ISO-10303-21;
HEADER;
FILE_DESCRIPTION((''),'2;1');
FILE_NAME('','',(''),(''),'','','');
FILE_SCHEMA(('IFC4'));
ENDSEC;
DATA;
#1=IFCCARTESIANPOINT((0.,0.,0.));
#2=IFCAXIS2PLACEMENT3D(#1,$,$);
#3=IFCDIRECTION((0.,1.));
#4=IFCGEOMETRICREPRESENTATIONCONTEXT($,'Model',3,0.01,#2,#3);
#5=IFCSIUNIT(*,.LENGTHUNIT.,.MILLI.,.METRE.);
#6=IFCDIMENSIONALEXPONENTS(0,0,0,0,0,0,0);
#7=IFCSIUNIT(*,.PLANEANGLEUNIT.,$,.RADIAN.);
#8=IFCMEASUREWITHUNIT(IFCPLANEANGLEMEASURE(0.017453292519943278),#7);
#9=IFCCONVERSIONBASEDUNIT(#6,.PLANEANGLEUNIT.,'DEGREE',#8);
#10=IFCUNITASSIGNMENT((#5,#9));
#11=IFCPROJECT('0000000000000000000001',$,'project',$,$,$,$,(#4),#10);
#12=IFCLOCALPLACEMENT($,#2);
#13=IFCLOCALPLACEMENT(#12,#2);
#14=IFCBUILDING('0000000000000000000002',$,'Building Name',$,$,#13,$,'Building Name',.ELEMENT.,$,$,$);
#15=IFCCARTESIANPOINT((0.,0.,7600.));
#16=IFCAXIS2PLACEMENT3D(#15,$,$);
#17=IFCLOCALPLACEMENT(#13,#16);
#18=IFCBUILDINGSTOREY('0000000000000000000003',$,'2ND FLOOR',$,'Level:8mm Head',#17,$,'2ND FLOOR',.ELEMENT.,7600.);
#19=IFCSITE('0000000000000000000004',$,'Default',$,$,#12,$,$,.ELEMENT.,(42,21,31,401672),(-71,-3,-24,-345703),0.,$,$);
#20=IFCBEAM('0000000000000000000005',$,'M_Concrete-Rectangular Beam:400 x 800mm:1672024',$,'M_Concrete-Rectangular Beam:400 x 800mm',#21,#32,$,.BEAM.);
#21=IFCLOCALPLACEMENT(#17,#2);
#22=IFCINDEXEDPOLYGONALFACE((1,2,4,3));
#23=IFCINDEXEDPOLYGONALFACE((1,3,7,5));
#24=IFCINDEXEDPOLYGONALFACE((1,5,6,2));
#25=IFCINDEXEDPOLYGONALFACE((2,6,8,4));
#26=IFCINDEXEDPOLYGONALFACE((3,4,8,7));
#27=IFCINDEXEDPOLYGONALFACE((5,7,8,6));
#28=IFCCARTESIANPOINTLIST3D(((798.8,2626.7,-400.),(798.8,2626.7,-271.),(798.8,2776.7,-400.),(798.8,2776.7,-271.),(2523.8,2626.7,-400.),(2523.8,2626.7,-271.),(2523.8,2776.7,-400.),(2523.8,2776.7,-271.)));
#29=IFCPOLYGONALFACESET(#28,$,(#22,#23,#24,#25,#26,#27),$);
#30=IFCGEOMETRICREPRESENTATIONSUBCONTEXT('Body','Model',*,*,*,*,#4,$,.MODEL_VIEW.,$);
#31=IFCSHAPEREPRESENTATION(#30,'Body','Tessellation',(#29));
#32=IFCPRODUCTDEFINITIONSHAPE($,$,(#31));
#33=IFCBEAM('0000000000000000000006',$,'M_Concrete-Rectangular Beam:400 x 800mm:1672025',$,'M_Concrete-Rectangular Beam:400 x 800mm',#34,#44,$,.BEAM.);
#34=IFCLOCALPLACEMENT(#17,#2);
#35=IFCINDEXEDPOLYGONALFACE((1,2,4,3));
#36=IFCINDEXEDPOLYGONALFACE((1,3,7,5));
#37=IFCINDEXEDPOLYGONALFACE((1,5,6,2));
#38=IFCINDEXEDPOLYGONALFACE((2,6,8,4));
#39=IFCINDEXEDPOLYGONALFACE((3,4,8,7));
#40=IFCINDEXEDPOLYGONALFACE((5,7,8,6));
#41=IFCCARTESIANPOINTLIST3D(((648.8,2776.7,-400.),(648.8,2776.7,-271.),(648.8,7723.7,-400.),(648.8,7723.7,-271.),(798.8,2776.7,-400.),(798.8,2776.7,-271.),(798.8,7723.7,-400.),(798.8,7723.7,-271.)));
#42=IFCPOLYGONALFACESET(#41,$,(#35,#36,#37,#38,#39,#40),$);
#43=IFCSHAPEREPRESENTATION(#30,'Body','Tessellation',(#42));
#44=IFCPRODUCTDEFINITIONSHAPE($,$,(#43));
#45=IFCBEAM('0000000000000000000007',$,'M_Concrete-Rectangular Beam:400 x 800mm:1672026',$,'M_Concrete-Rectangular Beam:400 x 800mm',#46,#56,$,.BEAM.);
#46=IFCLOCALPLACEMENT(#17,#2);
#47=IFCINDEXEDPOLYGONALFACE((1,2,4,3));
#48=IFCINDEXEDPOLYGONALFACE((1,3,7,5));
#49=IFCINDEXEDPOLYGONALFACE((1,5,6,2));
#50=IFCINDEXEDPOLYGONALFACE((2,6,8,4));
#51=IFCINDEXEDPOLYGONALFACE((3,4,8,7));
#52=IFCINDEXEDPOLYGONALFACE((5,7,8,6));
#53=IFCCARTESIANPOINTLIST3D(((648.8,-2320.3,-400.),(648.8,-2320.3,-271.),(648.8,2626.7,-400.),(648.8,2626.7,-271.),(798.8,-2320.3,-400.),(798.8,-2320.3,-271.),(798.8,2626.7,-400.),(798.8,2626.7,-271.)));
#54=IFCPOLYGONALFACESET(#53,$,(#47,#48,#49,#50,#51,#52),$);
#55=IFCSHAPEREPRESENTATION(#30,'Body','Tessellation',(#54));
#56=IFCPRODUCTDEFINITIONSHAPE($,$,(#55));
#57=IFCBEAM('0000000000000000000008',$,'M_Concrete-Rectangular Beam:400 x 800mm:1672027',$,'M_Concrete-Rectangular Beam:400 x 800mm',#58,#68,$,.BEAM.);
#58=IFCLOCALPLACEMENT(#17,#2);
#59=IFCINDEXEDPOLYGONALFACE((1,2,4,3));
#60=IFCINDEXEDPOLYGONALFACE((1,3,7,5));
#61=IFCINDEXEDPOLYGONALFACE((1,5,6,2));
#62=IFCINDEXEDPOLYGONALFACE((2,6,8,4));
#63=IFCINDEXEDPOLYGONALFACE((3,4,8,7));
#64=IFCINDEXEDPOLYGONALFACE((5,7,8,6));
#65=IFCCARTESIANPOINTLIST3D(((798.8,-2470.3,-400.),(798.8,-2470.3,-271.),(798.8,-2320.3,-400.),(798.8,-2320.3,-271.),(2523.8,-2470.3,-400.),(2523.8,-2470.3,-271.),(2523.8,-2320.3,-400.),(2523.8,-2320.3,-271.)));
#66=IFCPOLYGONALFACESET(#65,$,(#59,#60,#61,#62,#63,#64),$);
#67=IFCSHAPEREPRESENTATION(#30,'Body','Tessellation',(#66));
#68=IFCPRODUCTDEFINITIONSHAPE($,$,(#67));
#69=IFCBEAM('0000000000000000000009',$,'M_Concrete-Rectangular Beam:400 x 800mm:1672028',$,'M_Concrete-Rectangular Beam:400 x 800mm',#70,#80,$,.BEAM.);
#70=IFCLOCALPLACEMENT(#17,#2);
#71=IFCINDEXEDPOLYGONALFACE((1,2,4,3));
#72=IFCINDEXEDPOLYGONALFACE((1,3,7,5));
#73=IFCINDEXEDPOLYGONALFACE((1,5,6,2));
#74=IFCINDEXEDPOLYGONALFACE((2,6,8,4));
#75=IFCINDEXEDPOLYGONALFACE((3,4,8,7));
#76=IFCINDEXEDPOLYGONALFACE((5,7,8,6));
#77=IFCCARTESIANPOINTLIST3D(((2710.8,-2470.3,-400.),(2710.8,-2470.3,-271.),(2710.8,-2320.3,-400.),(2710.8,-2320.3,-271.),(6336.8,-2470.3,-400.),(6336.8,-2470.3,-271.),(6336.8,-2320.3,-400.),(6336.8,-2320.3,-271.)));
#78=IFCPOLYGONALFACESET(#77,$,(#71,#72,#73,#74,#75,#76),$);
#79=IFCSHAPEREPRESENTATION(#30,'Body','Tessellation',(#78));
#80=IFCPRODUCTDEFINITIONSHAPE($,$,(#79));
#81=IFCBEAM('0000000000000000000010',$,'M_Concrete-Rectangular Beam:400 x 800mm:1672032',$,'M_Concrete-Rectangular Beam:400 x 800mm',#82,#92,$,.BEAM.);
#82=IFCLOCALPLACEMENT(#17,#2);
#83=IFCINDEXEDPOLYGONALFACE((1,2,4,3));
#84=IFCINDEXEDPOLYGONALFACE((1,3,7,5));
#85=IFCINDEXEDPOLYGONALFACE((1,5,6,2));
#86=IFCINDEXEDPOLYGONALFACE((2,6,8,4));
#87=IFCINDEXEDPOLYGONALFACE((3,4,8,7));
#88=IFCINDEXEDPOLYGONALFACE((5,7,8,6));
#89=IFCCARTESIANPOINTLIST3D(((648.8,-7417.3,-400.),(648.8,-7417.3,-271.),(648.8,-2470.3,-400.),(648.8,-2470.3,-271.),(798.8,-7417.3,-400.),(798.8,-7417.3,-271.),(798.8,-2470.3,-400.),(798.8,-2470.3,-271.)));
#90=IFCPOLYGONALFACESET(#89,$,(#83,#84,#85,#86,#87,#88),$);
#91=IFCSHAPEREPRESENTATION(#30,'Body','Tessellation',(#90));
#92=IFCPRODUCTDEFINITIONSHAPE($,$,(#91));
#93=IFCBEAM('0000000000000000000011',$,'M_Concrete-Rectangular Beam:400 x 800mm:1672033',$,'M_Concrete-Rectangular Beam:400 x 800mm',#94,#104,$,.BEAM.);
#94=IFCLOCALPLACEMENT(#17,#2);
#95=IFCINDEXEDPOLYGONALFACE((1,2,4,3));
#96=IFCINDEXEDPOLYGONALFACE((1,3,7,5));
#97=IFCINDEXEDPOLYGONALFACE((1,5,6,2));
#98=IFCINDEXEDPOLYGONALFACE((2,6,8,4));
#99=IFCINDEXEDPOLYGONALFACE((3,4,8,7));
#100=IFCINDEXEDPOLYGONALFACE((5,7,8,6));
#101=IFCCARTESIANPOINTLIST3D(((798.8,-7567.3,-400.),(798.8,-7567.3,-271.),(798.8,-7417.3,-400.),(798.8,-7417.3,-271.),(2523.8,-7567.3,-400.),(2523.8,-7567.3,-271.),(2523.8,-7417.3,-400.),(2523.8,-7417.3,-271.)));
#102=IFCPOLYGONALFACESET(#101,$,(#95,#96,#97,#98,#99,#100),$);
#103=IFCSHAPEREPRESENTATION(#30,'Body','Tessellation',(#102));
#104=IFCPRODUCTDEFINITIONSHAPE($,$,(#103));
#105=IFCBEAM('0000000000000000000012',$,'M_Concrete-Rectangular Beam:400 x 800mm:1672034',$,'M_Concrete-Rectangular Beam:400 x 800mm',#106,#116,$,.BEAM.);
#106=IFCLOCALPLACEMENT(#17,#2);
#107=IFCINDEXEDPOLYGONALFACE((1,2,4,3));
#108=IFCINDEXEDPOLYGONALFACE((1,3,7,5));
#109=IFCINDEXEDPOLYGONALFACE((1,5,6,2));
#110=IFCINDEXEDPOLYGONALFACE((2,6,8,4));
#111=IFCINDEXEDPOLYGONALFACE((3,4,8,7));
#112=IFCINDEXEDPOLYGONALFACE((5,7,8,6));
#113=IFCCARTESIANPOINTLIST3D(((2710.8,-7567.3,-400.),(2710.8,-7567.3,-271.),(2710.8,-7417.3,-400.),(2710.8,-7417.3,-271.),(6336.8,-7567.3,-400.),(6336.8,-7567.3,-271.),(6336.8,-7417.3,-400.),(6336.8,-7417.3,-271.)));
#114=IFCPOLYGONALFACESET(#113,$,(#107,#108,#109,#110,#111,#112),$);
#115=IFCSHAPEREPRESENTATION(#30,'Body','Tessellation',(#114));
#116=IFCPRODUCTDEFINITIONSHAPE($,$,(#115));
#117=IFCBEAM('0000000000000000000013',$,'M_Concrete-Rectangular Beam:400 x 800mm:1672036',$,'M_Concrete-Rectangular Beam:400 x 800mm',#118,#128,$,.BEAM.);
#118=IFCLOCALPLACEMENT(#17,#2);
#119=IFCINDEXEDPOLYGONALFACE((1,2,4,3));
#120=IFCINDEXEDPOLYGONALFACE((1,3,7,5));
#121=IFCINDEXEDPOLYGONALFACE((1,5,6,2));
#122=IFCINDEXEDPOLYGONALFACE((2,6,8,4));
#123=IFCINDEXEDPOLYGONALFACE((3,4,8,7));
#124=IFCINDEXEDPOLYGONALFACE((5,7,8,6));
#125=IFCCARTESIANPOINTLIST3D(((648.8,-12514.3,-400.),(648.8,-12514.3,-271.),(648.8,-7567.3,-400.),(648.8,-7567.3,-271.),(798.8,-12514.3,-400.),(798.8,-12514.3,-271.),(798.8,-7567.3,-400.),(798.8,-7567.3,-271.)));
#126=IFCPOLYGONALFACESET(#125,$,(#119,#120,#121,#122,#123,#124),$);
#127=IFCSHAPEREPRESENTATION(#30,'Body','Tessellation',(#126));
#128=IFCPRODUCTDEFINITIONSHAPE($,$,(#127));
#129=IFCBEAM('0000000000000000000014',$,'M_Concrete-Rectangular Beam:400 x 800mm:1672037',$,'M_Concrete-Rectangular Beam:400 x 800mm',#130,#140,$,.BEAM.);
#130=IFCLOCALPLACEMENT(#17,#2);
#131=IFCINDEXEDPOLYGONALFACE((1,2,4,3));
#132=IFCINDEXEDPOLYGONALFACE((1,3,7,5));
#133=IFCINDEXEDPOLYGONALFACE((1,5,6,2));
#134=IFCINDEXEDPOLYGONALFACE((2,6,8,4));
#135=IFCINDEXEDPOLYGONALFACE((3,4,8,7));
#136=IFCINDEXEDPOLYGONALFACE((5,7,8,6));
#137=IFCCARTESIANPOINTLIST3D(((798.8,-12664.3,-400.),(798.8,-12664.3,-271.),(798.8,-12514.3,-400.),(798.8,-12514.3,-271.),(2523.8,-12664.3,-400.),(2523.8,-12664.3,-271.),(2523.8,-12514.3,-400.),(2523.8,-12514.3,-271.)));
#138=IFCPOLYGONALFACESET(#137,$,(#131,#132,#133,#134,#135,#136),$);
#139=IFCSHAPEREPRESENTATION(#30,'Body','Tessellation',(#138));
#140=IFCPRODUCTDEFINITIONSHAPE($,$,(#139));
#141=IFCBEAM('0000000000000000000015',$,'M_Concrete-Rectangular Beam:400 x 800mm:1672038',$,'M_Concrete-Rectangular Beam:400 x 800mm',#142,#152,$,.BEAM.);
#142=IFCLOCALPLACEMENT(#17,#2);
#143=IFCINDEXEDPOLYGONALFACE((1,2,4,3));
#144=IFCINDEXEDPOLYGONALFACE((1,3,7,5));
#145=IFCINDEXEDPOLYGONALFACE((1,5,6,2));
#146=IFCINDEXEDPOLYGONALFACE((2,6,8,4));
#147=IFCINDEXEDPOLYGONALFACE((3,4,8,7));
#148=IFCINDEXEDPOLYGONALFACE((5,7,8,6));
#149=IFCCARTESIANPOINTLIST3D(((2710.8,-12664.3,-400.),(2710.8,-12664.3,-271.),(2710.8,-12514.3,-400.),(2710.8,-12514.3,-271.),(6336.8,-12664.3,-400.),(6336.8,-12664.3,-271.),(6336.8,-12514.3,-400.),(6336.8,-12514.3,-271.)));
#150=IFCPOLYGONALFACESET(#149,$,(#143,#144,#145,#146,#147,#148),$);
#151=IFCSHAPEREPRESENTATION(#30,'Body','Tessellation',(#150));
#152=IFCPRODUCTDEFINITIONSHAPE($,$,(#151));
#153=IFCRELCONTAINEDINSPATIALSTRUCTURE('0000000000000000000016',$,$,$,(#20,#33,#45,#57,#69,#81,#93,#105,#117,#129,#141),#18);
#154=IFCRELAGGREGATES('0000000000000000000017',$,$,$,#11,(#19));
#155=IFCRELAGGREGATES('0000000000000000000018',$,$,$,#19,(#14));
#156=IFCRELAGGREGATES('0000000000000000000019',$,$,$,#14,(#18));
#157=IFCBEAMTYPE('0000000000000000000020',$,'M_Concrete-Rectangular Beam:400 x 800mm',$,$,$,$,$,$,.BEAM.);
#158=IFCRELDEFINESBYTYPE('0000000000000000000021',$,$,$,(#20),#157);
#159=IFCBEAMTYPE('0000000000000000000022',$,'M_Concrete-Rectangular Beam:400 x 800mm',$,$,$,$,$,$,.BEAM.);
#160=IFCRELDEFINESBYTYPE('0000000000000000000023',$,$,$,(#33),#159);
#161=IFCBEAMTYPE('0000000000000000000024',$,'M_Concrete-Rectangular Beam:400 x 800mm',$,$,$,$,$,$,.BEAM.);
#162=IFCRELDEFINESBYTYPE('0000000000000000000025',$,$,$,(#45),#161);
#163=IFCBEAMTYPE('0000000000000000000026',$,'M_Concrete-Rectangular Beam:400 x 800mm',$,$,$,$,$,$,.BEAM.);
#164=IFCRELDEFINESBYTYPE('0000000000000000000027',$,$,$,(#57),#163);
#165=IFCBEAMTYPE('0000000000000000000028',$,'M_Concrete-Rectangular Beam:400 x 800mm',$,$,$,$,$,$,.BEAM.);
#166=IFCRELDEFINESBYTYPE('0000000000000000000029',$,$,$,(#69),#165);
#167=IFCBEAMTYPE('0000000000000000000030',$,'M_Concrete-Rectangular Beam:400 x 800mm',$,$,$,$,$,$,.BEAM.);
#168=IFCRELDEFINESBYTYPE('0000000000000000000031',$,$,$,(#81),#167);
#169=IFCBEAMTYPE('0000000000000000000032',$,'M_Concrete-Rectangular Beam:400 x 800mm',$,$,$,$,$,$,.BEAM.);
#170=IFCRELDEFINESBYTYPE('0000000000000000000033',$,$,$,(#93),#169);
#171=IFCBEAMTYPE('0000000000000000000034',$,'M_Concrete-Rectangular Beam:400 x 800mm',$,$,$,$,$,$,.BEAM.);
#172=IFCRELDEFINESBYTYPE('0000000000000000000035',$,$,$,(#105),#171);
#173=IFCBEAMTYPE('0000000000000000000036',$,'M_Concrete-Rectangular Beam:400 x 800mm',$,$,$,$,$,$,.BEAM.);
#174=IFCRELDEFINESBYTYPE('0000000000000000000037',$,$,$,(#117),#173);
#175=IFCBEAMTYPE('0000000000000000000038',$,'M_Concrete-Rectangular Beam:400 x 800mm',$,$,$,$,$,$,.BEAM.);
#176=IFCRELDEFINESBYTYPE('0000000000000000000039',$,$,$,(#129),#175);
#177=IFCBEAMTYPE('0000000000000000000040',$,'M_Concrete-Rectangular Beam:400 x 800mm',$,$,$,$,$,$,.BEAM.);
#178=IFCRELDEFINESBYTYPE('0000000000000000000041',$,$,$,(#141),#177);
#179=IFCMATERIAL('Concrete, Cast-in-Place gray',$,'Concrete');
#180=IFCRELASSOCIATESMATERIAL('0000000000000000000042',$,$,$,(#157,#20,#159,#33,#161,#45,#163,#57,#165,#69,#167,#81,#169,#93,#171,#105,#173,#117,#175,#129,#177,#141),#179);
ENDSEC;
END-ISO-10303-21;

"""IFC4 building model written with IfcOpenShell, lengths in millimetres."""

from ifc_helpers import new_model, entity, si_unit, converted_unit, direction, frame, origin, place, context, subcontext, project, spatial, indexed_curve, outline, extrude, source, transform, mapped, material, type_object, type_shapes, element, save


model = new_model("IFC4")

# Units and contexts
model_context = context("Model", 3, precision=0.01, world=origin(), true_north=direction((0.0, 1.0)))
body_context = subcontext(model_context, "Body", "Model", "MODEL_VIEW")
ifc_project = project(units=[si_unit("LENGTHUNIT", "METRE", prefix="MILLI"), converted_unit("PLANEANGLEUNIT", "DEGREE", entity("IfcPlaneAngleMeasure", 0.017453292519943278), si_unit("PLANEANGLEUNIT", "RADIAN"), dimensions=[0, 0, 0, 0, 0, 0, 0])], contexts=[model_context])

# Site, building, storey
site_placement = place(None, origin())
site = spatial("IfcSite", under=ifc_project, at=site_placement, Name="Default", CompositionType="ELEMENT", RefLatitude=(42, 21, 31, 401672), RefLongitude=(-71, -3, -24, -345703), RefElevation=0.0)
building_placement = place(site_placement, origin())
building = spatial("IfcBuilding", under=site, at=building_placement, Name="Building Name", LongName="Building Name", CompositionType="ELEMENT")
storey_placement = place(building_placement, frame((0.0, 0.0, 7600.0)))
storey = spatial("IfcBuildingStorey", under=building, at=storey_placement, Name="2ND FLOOR", ObjectType="Level:8mm Head", LongName="2ND FLOOR", CompositionType="ELEMENT", Elevation=7600.0)

# Shared definitions
ifc_material_1 = material(Name="Concrete, Cast-in-Place gray", Category="Concrete")

# Beams
beam_type_1 = type_object("IfcBeamType", Name="M_Concrete-Rectangular Beam:400 x 800mm", PredefinedType="BEAM", material=ifc_material_1)
shared_shape_1 = source(origin(), body_context, "Body", "SweptSolid", [
    extrude(outline(indexed_curve([(-64.5, -75.0), (64.5, -75.0), (64.5, 75.0), (-64.5, 75.0), (-64.5, -75.0)], self_intersect=False)), frame((2523.8, 2701.7, 7264.5), z_axis=(-1.0, 0.0, 0.0), x_axis=(0.0, 0.0, -1.0)), (0.0, 0.0, 1.0), 1725.0),
])
type_shapes(beam_type_1, [shared_shape_1])
beam_1_placement = place(storey_placement, frame((0.0, 0.0, -7600.0)))
element("IfcBeam", 1, at=beam_1_placement, inside=storey, type_object=beam_type_1, material=ifc_material_1, Name="M_Concrete-Rectangular Beam:400 x 800mm:1672024", ObjectType="M_Concrete-Rectangular Beam:400 x 800mm", PredefinedType="BEAM", context=body_context, shape_type="MappedRepresentation", body=[
    mapped(shared_shape_1, transform((0.0, 0.0, 0.0), scale=1.0)),
])
beam_type_2 = type_object("IfcBeamType", Name="M_Concrete-Rectangular Beam:400 x 800mm", PredefinedType="BEAM", material=ifc_material_1)
shared_shape_2 = source(origin(), body_context, "Body", "SweptSolid", [
    extrude(outline(indexed_curve([(-75.0, -64.5), (75.0, -64.5), (75.0, 64.5), (-75.0, 64.5), (-75.0, -64.5)], self_intersect=False)), frame((723.8, 2776.7, 7264.5), z_axis=(0.0, 1.0, 0.0), x_axis=(-1.0, 0.0, 0.0)), (0.0, 0.0, 1.0), 4947.0),
])
type_shapes(beam_type_2, [shared_shape_2])
beam_2_placement = place(storey_placement, frame((0.0, 0.0, -7600.0)))
element("IfcBeam", 2, at=beam_2_placement, inside=storey, type_object=beam_type_2, material=ifc_material_1, Name="M_Concrete-Rectangular Beam:400 x 800mm:1672025", ObjectType="M_Concrete-Rectangular Beam:400 x 800mm", PredefinedType="BEAM", context=body_context, shape_type="MappedRepresentation", body=[
    mapped(shared_shape_2, transform((0.0, 0.0, 0.0), scale=1.0)),
])
beam_type_3 = type_object("IfcBeamType", Name="M_Concrete-Rectangular Beam:400 x 800mm", PredefinedType="BEAM", material=ifc_material_1)
shared_shape_3 = source(origin(), body_context, "Body", "SweptSolid", [
    extrude(outline(indexed_curve([(-75.0, -64.5), (75.0, -64.5), (75.0, 64.5), (-75.0, 64.5), (-75.0, -64.5)], self_intersect=False)), frame((723.8, 2626.7, 7264.5), z_axis=(0.0, -1.0, 0.0), x_axis=(-1.0, 0.0, 0.0)), (0.0, 0.0, 1.0), 4947.0),
])
type_shapes(beam_type_3, [shared_shape_3])
beam_3_placement = place(storey_placement, frame((0.0, 0.0, -7600.0)))
element("IfcBeam", 3, at=beam_3_placement, inside=storey, type_object=beam_type_3, material=ifc_material_1, Name="M_Concrete-Rectangular Beam:400 x 800mm:1672026", ObjectType="M_Concrete-Rectangular Beam:400 x 800mm", PredefinedType="BEAM", context=body_context, shape_type="MappedRepresentation", body=[
    mapped(shared_shape_3, transform((0.0, 0.0, 0.0), scale=1.0)),
])
beam_type_4 = type_object("IfcBeamType", Name="M_Concrete-Rectangular Beam:400 x 800mm", PredefinedType="BEAM", material=ifc_material_1)
shared_shape_4 = source(origin(), body_context, "Body", "SweptSolid", [
    extrude(outline(indexed_curve([(-64.5, -75.0), (64.5, -75.0), (64.5, 75.0), (-64.5, 75.0), (-64.5, -75.0)], self_intersect=False)), frame((798.8, -2395.3, 7264.5), z_axis=(1.0, 0.0, 0.0), x_axis=(0.0, 0.0, -1.0)), (0.0, 0.0, 1.0), 1725.0),
])
type_shapes(beam_type_4, [shared_shape_4])
beam_4_placement = place(storey_placement, frame((0.0, 0.0, -7600.0)))
element("IfcBeam", 4, at=beam_4_placement, inside=storey, type_object=beam_type_4, material=ifc_material_1, Name="M_Concrete-Rectangular Beam:400 x 800mm:1672027", ObjectType="M_Concrete-Rectangular Beam:400 x 800mm", PredefinedType="BEAM", context=body_context, shape_type="MappedRepresentation", body=[
    mapped(shared_shape_4, transform((0.0, 0.0, 0.0), scale=1.0)),
])
beam_type_5 = type_object("IfcBeamType", Name="M_Concrete-Rectangular Beam:400 x 800mm", PredefinedType="BEAM", material=ifc_material_1)
shared_shape_5 = source(origin(), body_context, "Body", "SweptSolid", [
    extrude(outline(indexed_curve([(-64.5, -75.0), (64.5, -75.0), (64.5, 75.0), (-64.5, 75.0), (-64.5, -75.0)], self_intersect=False)), frame((2710.8, -2395.3, 7264.5), z_axis=(1.0, 0.0, 0.0), x_axis=(0.0, 0.0, -1.0)), (0.0, 0.0, 1.0), 3626.0),
])
type_shapes(beam_type_5, [shared_shape_5])
beam_5_placement = place(storey_placement, frame((0.0, 0.0, -7600.0)))
element("IfcBeam", 5, at=beam_5_placement, inside=storey, type_object=beam_type_5, material=ifc_material_1, Name="M_Concrete-Rectangular Beam:400 x 800mm:1672028", ObjectType="M_Concrete-Rectangular Beam:400 x 800mm", PredefinedType="BEAM", context=body_context, shape_type="MappedRepresentation", body=[
    mapped(shared_shape_5, transform((0.0, 0.0, 0.0), scale=1.0)),
])
beam_type_6 = type_object("IfcBeamType", Name="M_Concrete-Rectangular Beam:400 x 800mm", PredefinedType="BEAM", material=ifc_material_1)
shared_shape_6 = source(origin(), body_context, "Body", "SweptSolid", [
    extrude(outline(indexed_curve([(-75.0, -64.5), (75.0, -64.5), (75.0, 64.5), (-75.0, 64.5), (-75.0, -64.5)], self_intersect=False)), frame((723.8, -2470.3, 7264.5), z_axis=(0.0, -1.0, 0.0), x_axis=(-1.0, 0.0, 0.0)), (0.0, 0.0, 1.0), 4947.0),
])
type_shapes(beam_type_6, [shared_shape_6])
beam_6_placement = place(storey_placement, frame((0.0, 0.0, -7600.0)))
element("IfcBeam", 6, at=beam_6_placement, inside=storey, type_object=beam_type_6, material=ifc_material_1, Name="M_Concrete-Rectangular Beam:400 x 800mm:1672032", ObjectType="M_Concrete-Rectangular Beam:400 x 800mm", PredefinedType="BEAM", context=body_context, shape_type="MappedRepresentation", body=[
    mapped(shared_shape_6, transform((0.0, 0.0, 0.0), scale=1.0)),
])
beam_type_7 = type_object("IfcBeamType", Name="M_Concrete-Rectangular Beam:400 x 800mm", PredefinedType="BEAM", material=ifc_material_1)
shared_shape_7 = source(origin(), body_context, "Body", "SweptSolid", [
    extrude(outline(indexed_curve([(-64.5, -75.0), (64.5, -75.0), (64.5, 75.0), (-64.5, 75.0), (-64.5, -75.0)], self_intersect=False)), frame((798.8, -7492.3, 7264.5), z_axis=(1.0, 0.0, 0.0), x_axis=(0.0, 0.0, -1.0)), (0.0, 0.0, 1.0), 1725.0),
])
type_shapes(beam_type_7, [shared_shape_7])
beam_7_placement = place(storey_placement, frame((0.0, 0.0, -7600.0)))
element("IfcBeam", 7, at=beam_7_placement, inside=storey, type_object=beam_type_7, material=ifc_material_1, Name="M_Concrete-Rectangular Beam:400 x 800mm:1672033", ObjectType="M_Concrete-Rectangular Beam:400 x 800mm", PredefinedType="BEAM", context=body_context, shape_type="MappedRepresentation", body=[
    mapped(shared_shape_7, transform((0.0, 0.0, 0.0), scale=1.0)),
])
beam_type_8 = type_object("IfcBeamType", Name="M_Concrete-Rectangular Beam:400 x 800mm", PredefinedType="BEAM", material=ifc_material_1)
shared_shape_8 = source(origin(), body_context, "Body", "SweptSolid", [
    extrude(outline(indexed_curve([(-64.5, -75.0), (64.5, -75.0), (64.5, 75.0), (-64.5, 75.0), (-64.5, -75.0)], self_intersect=False)), frame((2710.8, -7492.3, 7264.5), z_axis=(1.0, 0.0, 0.0), x_axis=(0.0, 0.0, -1.0)), (0.0, 0.0, 1.0), 3626.0),
])
type_shapes(beam_type_8, [shared_shape_8])
beam_8_placement = place(storey_placement, frame((0.0, 0.0, -7600.0)))
element("IfcBeam", 8, at=beam_8_placement, inside=storey, type_object=beam_type_8, material=ifc_material_1, Name="M_Concrete-Rectangular Beam:400 x 800mm:1672034", ObjectType="M_Concrete-Rectangular Beam:400 x 800mm", PredefinedType="BEAM", context=body_context, shape_type="MappedRepresentation", body=[
    mapped(shared_shape_8, transform((0.0, 0.0, 0.0), scale=1.0)),
])
beam_type_9 = type_object("IfcBeamType", Name="M_Concrete-Rectangular Beam:400 x 800mm", PredefinedType="BEAM", material=ifc_material_1)
shared_shape_9 = source(origin(), body_context, "Body", "SweptSolid", [
    extrude(outline(indexed_curve([(-75.0, -64.5), (75.0, -64.5), (75.0, 64.5), (-75.0, 64.5), (-75.0, -64.5)], self_intersect=False)), frame((723.8, -7567.3, 7264.5), z_axis=(0.0, -1.0, 0.0), x_axis=(-1.0, 0.0, 0.0)), (0.0, 0.0, 1.0), 4947.0),
])
type_shapes(beam_type_9, [shared_shape_9])
beam_9_placement = place(storey_placement, frame((0.0, 0.0, -7600.0)))
element("IfcBeam", 9, at=beam_9_placement, inside=storey, type_object=beam_type_9, material=ifc_material_1, Name="M_Concrete-Rectangular Beam:400 x 800mm:1672036", ObjectType="M_Concrete-Rectangular Beam:400 x 800mm", PredefinedType="BEAM", context=body_context, shape_type="MappedRepresentation", body=[
    mapped(shared_shape_9, transform((0.0, 0.0, 0.0), scale=1.0)),
])
beam_type_10 = type_object("IfcBeamType", Name="M_Concrete-Rectangular Beam:400 x 800mm", PredefinedType="BEAM", material=ifc_material_1)
shared_shape_10 = source(origin(), body_context, "Body", "SweptSolid", [
    extrude(outline(indexed_curve([(-64.5, -75.0), (64.5, -75.0), (64.5, 75.0), (-64.5, 75.0), (-64.5, -75.0)], self_intersect=False)), frame((798.8, -12589.3, 7264.5), z_axis=(1.0, 0.0, 0.0), x_axis=(0.0, 0.0, -1.0)), (0.0, 0.0, 1.0), 1725.0),
])
type_shapes(beam_type_10, [shared_shape_10])
beam_10_placement = place(storey_placement, frame((0.0, 0.0, -7600.0)))
element("IfcBeam", 10, at=beam_10_placement, inside=storey, type_object=beam_type_10, material=ifc_material_1, Name="M_Concrete-Rectangular Beam:400 x 800mm:1672037", ObjectType="M_Concrete-Rectangular Beam:400 x 800mm", PredefinedType="BEAM", context=body_context, shape_type="MappedRepresentation", body=[
    mapped(shared_shape_10, transform((0.0, 0.0, 0.0), scale=1.0)),
])
beam_type_11 = type_object("IfcBeamType", Name="M_Concrete-Rectangular Beam:400 x 800mm", PredefinedType="BEAM", material=ifc_material_1)
shared_shape_11 = source(origin(), body_context, "Body", "SweptSolid", [
    extrude(outline(indexed_curve([(-64.5, -75.0), (64.5, -75.0), (64.5, 75.0), (-64.5, 75.0), (-64.5, -75.0)], self_intersect=False)), frame((2710.8, -12589.3, 7264.5), z_axis=(1.0, 0.0, 0.0), x_axis=(0.0, 0.0, -1.0)), (0.0, 0.0, 1.0), 3626.0),
])
type_shapes(beam_type_11, [shared_shape_11])
beam_11_placement = place(storey_placement, frame((0.0, 0.0, -7600.0)))
element("IfcBeam", 11, at=beam_11_placement, inside=storey, type_object=beam_type_11, material=ifc_material_1, Name="M_Concrete-Rectangular Beam:400 x 800mm:1672038", ObjectType="M_Concrete-Rectangular Beam:400 x 800mm", PredefinedType="BEAM", context=body_context, shape_type="MappedRepresentation", body=[
    mapped(shared_shape_11, transform((0.0, 0.0, 0.0), scale=1.0)),
])

save(model, "model.ifc")
